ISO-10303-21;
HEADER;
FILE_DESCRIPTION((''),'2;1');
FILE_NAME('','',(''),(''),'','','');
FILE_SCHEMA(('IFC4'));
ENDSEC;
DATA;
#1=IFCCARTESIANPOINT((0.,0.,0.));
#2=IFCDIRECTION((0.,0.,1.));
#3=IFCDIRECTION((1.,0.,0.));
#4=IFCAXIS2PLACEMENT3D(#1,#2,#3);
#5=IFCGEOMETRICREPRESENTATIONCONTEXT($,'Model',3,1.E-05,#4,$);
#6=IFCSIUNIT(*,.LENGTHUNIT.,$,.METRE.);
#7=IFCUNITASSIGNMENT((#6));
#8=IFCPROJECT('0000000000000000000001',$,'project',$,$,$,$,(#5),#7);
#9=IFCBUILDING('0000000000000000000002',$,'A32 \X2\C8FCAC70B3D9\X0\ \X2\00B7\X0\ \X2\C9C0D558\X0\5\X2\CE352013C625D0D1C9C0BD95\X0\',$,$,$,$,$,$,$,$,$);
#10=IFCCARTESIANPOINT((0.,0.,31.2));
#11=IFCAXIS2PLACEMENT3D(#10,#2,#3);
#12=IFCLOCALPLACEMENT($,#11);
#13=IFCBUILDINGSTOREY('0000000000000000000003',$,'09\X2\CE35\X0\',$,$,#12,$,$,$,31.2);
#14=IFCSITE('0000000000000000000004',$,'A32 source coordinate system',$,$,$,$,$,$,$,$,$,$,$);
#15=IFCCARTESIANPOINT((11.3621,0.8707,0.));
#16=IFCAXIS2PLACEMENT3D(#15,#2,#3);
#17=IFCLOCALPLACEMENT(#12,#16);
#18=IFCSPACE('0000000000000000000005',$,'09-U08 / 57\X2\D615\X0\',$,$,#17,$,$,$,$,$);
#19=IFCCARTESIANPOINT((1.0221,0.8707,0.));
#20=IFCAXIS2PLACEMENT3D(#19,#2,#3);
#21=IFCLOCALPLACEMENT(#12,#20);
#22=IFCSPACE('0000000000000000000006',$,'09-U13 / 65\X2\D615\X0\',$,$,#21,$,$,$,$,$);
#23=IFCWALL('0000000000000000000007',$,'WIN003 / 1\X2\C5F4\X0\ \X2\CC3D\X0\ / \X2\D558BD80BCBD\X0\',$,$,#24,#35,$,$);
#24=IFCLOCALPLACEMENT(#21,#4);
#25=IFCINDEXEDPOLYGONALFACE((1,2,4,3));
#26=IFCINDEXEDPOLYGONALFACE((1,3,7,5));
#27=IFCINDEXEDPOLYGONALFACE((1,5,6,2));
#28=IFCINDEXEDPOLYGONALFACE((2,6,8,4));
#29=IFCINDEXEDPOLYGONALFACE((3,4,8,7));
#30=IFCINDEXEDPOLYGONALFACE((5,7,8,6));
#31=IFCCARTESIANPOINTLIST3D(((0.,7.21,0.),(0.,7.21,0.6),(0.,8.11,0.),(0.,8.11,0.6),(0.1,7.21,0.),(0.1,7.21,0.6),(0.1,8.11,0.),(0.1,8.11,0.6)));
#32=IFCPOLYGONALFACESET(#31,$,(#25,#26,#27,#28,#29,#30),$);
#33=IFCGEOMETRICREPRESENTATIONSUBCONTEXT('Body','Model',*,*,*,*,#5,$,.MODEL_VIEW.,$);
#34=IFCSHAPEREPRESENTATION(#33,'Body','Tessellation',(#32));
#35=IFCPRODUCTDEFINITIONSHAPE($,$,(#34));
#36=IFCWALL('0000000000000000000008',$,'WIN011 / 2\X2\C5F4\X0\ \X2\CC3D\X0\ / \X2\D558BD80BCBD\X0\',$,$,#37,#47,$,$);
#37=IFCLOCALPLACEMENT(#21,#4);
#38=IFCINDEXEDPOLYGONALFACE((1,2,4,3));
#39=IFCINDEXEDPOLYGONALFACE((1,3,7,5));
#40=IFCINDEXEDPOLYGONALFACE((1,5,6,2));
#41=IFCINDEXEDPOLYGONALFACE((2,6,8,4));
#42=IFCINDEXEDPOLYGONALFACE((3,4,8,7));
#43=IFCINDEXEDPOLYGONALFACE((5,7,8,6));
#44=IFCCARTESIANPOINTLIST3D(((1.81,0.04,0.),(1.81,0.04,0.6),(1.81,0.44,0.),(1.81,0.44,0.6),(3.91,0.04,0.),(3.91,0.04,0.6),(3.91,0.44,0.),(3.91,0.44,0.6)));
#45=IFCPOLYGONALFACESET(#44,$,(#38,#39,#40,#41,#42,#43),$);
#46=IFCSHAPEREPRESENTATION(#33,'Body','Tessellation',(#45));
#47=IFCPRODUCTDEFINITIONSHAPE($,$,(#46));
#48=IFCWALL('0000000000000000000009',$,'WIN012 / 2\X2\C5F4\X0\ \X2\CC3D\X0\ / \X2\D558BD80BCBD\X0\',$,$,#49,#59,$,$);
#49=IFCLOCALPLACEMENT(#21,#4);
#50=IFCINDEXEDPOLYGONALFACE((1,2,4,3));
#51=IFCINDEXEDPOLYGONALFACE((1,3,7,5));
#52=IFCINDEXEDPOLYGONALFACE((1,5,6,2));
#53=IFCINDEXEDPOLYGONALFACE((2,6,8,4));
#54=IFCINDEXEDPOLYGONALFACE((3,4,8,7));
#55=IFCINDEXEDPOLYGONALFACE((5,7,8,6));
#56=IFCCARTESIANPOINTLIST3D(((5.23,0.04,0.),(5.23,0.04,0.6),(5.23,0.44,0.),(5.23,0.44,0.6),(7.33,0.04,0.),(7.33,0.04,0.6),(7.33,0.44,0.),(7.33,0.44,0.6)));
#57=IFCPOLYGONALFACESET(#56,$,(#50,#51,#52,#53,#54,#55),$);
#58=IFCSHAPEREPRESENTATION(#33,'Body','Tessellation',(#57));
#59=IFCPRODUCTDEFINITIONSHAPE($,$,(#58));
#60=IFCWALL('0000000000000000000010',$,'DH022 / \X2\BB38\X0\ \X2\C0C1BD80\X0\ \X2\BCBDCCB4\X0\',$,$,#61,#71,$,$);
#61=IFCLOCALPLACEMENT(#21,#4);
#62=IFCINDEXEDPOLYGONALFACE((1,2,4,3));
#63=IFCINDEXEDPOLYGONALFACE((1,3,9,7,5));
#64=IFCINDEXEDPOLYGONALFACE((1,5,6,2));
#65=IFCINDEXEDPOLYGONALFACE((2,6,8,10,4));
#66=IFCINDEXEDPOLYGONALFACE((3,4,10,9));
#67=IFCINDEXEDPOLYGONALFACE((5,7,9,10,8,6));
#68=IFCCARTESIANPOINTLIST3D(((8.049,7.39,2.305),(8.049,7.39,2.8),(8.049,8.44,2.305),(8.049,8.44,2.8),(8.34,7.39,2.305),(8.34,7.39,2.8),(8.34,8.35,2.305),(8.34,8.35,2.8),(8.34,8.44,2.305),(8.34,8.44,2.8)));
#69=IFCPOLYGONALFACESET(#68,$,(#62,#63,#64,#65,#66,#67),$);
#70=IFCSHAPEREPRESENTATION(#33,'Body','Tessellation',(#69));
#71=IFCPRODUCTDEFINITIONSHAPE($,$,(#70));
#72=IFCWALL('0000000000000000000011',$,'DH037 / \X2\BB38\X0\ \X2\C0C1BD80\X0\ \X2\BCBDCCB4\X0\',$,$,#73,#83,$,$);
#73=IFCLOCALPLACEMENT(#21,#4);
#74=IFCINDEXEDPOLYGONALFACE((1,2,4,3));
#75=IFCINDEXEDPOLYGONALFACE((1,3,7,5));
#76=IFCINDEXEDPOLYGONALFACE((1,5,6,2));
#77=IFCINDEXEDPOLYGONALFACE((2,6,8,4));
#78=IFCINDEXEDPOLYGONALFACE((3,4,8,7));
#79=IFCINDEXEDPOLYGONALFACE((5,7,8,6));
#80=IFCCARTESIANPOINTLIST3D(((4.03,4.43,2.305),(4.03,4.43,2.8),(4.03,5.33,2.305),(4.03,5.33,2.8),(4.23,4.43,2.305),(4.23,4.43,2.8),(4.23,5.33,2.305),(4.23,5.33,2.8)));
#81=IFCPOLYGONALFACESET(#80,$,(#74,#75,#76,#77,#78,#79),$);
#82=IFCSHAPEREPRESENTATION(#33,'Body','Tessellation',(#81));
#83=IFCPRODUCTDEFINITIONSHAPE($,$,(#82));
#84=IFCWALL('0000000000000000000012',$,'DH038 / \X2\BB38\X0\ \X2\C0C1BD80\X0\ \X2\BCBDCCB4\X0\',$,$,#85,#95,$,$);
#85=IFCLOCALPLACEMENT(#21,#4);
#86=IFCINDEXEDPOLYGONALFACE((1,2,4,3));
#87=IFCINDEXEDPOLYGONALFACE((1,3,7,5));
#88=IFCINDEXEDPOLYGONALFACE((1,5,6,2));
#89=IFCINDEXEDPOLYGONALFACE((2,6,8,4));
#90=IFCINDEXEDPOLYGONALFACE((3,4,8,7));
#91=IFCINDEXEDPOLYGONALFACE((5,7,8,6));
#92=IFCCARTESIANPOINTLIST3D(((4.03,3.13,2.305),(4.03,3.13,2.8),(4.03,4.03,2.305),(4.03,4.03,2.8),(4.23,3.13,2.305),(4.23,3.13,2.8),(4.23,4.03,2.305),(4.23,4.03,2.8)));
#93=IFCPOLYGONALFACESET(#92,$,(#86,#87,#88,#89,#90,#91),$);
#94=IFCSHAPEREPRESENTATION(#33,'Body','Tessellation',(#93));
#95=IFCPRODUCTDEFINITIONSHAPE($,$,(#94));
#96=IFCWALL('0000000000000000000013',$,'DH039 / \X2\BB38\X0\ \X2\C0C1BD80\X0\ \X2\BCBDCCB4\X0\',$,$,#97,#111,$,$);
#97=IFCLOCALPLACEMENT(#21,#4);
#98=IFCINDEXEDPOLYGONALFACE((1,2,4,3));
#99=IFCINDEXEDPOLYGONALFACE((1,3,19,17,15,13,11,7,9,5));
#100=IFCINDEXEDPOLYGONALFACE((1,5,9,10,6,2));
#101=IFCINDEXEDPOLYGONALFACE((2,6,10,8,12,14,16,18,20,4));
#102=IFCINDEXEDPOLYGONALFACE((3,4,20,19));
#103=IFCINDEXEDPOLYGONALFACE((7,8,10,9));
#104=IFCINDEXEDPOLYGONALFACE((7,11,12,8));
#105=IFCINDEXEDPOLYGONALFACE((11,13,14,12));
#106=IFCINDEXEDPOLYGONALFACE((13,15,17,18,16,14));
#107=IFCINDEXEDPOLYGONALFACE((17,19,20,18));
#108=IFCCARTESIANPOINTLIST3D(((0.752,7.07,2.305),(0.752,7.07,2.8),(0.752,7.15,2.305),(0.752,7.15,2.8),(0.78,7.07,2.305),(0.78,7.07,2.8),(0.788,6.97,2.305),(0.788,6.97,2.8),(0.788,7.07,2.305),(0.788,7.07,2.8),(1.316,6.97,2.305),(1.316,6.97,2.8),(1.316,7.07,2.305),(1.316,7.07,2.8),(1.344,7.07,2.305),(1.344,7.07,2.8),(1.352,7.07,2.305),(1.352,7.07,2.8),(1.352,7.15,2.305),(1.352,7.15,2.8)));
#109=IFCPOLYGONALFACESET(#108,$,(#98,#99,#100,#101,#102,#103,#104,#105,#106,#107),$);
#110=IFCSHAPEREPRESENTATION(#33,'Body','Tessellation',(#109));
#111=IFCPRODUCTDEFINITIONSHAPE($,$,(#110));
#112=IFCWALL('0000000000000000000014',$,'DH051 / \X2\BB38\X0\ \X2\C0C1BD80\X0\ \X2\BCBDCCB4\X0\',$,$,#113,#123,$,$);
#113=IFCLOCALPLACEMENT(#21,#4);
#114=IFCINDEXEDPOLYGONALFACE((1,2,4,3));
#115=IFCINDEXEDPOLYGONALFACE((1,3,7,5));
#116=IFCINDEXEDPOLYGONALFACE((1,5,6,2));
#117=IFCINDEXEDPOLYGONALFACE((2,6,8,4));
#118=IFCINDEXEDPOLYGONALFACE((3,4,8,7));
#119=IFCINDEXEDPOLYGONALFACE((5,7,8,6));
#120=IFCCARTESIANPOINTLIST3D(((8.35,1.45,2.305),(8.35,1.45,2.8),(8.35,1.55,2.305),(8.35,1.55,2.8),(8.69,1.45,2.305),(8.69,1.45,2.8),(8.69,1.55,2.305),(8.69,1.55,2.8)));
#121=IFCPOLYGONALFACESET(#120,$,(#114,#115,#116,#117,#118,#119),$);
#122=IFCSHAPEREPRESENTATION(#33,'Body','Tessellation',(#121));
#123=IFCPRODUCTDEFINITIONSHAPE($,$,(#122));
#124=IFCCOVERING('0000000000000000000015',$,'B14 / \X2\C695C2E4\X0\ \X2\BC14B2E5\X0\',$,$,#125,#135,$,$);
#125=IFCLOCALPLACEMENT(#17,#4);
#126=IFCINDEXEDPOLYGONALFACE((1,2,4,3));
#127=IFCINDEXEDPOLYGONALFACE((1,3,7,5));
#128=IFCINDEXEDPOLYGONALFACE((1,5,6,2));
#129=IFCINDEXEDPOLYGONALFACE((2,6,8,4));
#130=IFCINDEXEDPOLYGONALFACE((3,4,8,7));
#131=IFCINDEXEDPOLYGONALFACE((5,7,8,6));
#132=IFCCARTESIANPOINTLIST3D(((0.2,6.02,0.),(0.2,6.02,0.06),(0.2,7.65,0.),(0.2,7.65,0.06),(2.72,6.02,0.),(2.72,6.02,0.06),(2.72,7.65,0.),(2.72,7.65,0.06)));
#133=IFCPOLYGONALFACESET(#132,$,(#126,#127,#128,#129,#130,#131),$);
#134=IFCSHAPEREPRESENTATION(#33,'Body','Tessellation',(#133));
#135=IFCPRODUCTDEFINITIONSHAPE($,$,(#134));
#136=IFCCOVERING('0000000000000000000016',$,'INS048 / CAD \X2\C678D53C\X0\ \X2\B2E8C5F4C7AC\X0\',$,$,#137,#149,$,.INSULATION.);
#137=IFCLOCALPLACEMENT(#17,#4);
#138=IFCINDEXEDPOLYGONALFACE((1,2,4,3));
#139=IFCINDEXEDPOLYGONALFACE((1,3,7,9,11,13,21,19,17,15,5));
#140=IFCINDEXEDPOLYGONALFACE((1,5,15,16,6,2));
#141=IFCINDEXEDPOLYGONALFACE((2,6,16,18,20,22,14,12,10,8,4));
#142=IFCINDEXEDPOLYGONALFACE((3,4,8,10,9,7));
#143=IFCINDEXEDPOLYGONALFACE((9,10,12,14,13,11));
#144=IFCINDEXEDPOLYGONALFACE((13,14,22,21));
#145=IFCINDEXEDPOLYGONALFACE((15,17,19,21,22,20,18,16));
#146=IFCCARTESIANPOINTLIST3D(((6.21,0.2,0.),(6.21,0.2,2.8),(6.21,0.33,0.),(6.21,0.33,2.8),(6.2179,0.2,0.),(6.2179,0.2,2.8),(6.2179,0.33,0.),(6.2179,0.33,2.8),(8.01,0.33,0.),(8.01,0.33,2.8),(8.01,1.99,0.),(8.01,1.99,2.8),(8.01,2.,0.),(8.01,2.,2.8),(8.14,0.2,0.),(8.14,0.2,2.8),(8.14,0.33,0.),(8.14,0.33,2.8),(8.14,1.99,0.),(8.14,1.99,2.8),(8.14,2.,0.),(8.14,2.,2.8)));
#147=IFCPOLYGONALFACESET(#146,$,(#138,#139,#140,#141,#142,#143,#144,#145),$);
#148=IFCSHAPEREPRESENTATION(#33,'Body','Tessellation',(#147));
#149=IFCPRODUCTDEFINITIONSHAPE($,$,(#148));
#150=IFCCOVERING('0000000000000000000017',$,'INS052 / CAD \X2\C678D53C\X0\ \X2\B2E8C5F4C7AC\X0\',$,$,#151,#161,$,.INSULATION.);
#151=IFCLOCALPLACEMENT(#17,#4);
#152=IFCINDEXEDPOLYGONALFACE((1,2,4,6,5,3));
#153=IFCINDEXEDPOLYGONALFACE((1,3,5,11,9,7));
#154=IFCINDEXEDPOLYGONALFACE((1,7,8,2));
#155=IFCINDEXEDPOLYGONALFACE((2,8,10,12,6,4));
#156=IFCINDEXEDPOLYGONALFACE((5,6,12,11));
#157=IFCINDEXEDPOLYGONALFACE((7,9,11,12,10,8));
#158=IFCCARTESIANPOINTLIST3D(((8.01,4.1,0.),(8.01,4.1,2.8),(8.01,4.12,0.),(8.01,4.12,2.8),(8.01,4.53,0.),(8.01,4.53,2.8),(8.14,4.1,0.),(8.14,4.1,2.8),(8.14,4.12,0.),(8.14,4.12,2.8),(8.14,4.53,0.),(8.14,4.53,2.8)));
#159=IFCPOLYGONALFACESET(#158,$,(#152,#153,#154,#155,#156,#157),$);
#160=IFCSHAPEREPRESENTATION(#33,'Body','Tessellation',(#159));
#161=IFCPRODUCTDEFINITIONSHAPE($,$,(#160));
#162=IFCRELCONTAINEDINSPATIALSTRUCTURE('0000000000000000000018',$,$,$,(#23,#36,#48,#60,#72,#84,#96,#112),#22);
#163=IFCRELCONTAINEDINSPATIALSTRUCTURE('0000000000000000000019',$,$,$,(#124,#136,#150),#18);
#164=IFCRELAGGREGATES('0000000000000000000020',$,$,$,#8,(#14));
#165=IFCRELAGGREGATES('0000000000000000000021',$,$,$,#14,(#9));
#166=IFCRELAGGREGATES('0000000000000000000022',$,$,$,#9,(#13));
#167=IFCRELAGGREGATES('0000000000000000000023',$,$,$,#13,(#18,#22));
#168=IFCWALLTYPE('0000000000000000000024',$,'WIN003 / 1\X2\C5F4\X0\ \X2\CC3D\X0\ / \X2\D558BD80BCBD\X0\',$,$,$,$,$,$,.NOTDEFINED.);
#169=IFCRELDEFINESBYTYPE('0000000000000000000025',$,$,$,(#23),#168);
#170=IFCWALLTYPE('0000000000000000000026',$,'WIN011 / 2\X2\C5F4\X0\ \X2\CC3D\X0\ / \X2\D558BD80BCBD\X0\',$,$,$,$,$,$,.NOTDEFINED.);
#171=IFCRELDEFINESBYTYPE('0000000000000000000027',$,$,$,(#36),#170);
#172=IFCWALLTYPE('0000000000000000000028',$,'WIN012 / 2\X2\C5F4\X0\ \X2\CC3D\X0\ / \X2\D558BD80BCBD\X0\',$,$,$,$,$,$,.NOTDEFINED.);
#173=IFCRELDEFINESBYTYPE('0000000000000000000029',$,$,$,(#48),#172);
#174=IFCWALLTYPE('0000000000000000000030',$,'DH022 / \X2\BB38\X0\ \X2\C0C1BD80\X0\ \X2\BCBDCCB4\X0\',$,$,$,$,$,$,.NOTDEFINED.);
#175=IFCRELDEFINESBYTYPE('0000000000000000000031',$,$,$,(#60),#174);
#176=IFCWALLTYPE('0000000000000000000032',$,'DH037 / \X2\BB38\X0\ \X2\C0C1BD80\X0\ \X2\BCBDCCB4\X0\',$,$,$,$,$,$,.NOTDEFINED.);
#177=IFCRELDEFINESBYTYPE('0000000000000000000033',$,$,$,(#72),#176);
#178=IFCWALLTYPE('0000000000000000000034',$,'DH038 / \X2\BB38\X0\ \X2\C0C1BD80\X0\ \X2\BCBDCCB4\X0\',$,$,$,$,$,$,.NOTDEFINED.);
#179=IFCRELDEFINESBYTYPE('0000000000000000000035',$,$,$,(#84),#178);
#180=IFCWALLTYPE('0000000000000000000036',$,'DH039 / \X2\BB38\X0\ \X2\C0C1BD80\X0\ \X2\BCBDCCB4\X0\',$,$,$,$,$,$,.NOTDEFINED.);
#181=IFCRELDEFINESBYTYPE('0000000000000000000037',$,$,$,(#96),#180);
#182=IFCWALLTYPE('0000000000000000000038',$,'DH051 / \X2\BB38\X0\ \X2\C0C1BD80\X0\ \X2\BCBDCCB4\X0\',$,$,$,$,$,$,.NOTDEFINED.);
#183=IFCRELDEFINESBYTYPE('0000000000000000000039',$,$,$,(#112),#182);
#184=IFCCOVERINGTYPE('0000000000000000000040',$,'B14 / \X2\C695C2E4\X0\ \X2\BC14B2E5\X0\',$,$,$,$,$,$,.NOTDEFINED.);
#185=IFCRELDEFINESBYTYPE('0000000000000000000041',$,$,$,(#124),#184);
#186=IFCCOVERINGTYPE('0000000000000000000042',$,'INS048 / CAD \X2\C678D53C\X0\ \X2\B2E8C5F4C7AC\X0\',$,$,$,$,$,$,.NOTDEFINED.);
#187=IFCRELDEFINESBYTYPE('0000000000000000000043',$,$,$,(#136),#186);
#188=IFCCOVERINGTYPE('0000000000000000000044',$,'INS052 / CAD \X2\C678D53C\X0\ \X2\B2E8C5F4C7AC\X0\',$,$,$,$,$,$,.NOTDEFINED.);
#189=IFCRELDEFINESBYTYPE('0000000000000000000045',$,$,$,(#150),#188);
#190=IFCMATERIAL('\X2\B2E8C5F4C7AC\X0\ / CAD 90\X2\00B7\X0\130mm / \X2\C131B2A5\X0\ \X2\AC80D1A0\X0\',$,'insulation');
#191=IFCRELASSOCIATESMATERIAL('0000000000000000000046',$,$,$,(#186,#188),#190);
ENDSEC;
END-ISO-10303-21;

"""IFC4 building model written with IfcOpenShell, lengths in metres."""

from ifc_helpers import new_model, si_unit, frame, origin, origin_with_axes, place, context, subcontext, project, spatial, polyline, outline, extrude, source, transform, mapped, material, type_object, type_shapes, element, save


model = new_model("IFC4")

# Units and contexts
model_context = context("Model", 3, precision=1e-05, world=origin_with_axes())
body_context = subcontext(model_context, "Body", "Model", "MODEL_VIEW")
ifc_project = project(units=[si_unit("LENGTHUNIT", "METRE")], contexts=[model_context])

# Site, building, storey, space
site = spatial("IfcSite", under=ifc_project, Name="A32 source coordinate system")
building = spatial("IfcBuilding", under=site, Name="A32 주거동 · 지하5층–옥탑지붕")
storey_placement = place(None, frame((0.0, 0.0, 31.2), z_axis=(0.0, 0.0, 1.0), x_axis=(1.0, 0.0, 0.0)))
storey = spatial("IfcBuildingStorey", under=building, at=storey_placement, Name="09층", Elevation=31.2)
space_1_placement = place(storey_placement, frame((11.3621, 0.8707, 0.0), z_axis=(0.0, 0.0, 1.0), x_axis=(1.0, 0.0, 0.0)))
space_1 = spatial("IfcSpace", under=storey, at=space_1_placement, Name="09-U08 / 57형")

# Shared definitions
space_2_placement = place(storey_placement, frame((1.0221, 0.8707, 0.0), z_axis=(0.0, 0.0, 1.0), x_axis=(1.0, 0.0, 0.0)))
space_2 = spatial("IfcSpace", under=storey, at=space_2_placement, Name="09-U13 / 65형")

# Walls
wall_type_1 = type_object("IfcWallType", Name="WIN003 / 1열 창 / 하부벽", PredefinedType="NOTDEFINED")
shared_shape_1 = source(origin(), body_context, "Body", "SweptSolid", [
    extrude(outline(polyline([(0.0, 8.11), (0.1, 8.11), (0.1, 7.21), (0.0, 7.21), (0.0, 8.11)])), origin(), (0.0, 0.0, 1.0), 0.6),
])
type_shapes(wall_type_1, [shared_shape_1])
wall_1_placement = place(space_2_placement, origin_with_axes())
element("IfcWall", 1, at=wall_1_placement, inside=space_2, type_object=wall_type_1, Name="WIN003 / 1열 창 / 하부벽", context=body_context, shape_type="MappedRepresentation", body=[
    mapped(shared_shape_1, transform((0.0, 0.0, 0.0), scale=1.0)),
])
wall_type_2 = type_object("IfcWallType", Name="WIN011 / 2열 창 / 하부벽", PredefinedType="NOTDEFINED")
shared_shape_2 = source(origin(), body_context, "Body", "SweptSolid", [
    extrude(outline(polyline([(1.81, 0.44), (3.91, 0.44), (3.91, 0.04), (1.81, 0.04), (1.81, 0.44)])), origin(), (0.0, 0.0, 1.0), 0.6),
])
type_shapes(wall_type_2, [shared_shape_2])
wall_2_placement = place(space_2_placement, origin_with_axes())
element("IfcWall", 2, at=wall_2_placement, inside=space_2, type_object=wall_type_2, Name="WIN011 / 2열 창 / 하부벽", context=body_context, shape_type="MappedRepresentation", body=[
    mapped(shared_shape_2, transform((0.0, 0.0, 0.0), scale=1.0)),
])
wall_type_3 = type_object("IfcWallType", Name="WIN012 / 2열 창 / 하부벽", PredefinedType="NOTDEFINED")
shared_shape_3 = source(origin(), body_context, "Body", "SweptSolid", [
    extrude(outline(polyline([(5.23, 0.44), (7.33, 0.44), (7.33, 0.04), (5.23, 0.04), (5.23, 0.44)])), origin(), (0.0, 0.0, 1.0), 0.6),
])
type_shapes(wall_type_3, [shared_shape_3])
wall_3_placement = place(space_2_placement, origin_with_axes())
element("IfcWall", 3, at=wall_3_placement, inside=space_2, type_object=wall_type_3, Name="WIN012 / 2열 창 / 하부벽", context=body_context, shape_type="MappedRepresentation", body=[
    mapped(shared_shape_3, transform((0.0, 0.0, 0.0), scale=1.0)),
])
wall_type_4 = type_object("IfcWallType", Name="DH022 / 문 상부 벽체", PredefinedType="NOTDEFINED")
shared_shape_4 = source(origin(), body_context, "Body", "SweptSolid", [
    extrude(outline(polyline([(8.049, 7.39), (8.049, 8.44), (8.34, 8.44), (8.34, 8.35), (8.34, 8.35), (8.34, 7.39), (8.049, 7.39)])), frame((0.0, 0.0, 2.305)), (0.0, 0.0, 1.0), 0.495),
])
type_shapes(wall_type_4, [shared_shape_4])
wall_4_placement = place(space_2_placement, origin_with_axes())
element("IfcWall", 4, at=wall_4_placement, inside=space_2, type_object=wall_type_4, Name="DH022 / 문 상부 벽체", context=body_context, shape_type="MappedRepresentation", body=[
    mapped(shared_shape_4, transform((0.0, 0.0, 0.0), scale=1.0)),
])
wall_type_5 = type_object("IfcWallType", Name="DH037 / 문 상부 벽체", PredefinedType="NOTDEFINED")
shared_shape_5 = source(origin(), body_context, "Body", "SweptSolid", [
    extrude(outline(polyline([(4.23, 5.33), (4.23, 4.43), (4.03, 4.43), (4.03, 5.33), (4.23, 5.33)])), frame((0.0, 0.0, 2.305)), (0.0, 0.0, 1.0), 0.495),
])
type_shapes(wall_type_5, [shared_shape_5])
wall_5_placement = place(space_2_placement, origin_with_axes())
element("IfcWall", 5, at=wall_5_placement, inside=space_2, type_object=wall_type_5, Name="DH037 / 문 상부 벽체", context=body_context, shape_type="MappedRepresentation", body=[
    mapped(shared_shape_5, transform((0.0, 0.0, 0.0), scale=1.0)),
])
wall_type_6 = type_object("IfcWallType", Name="DH038 / 문 상부 벽체", PredefinedType="NOTDEFINED")
shared_shape_6 = source(origin(), body_context, "Body", "SweptSolid", [
    extrude(outline(polyline([(4.23, 4.03), (4.23, 3.13), (4.03, 3.13), (4.03, 4.03), (4.23, 4.03)])), frame((0.0, 0.0, 2.305)), (0.0, 0.0, 1.0), 0.495),
])
type_shapes(wall_type_6, [shared_shape_6])
wall_6_placement = place(space_2_placement, origin_with_axes())
element("IfcWall", 6, at=wall_6_placement, inside=space_2, type_object=wall_type_6, Name="DH038 / 문 상부 벽체", context=body_context, shape_type="MappedRepresentation", body=[
    mapped(shared_shape_6, transform((0.0, 0.0, 0.0), scale=1.0)),
])
wall_type_7 = type_object("IfcWallType", Name="DH039 / 문 상부 벽체", PredefinedType="NOTDEFINED")
shared_shape_7 = source(origin(), body_context, "Body", "SweptSolid", [
    extrude(outline(polyline([(1.316, 7.07), (1.316, 6.97), (0.788, 6.97), (0.788, 7.07), (0.78, 7.07), (0.752, 7.07), (0.752, 7.15), (1.352, 7.15), (1.352, 7.07), (1.344, 7.07), (1.316, 7.07)])), frame((0.0, 0.0, 2.305)), (0.0, 0.0, 1.0), 0.495),
])
type_shapes(wall_type_7, [shared_shape_7])
wall_7_placement = place(space_2_placement, origin_with_axes())
element("IfcWall", 7, at=wall_7_placement, inside=space_2, type_object=wall_type_7, Name="DH039 / 문 상부 벽체", context=body_context, shape_type="MappedRepresentation", body=[
    mapped(shared_shape_7, transform((0.0, 0.0, 0.0), scale=1.0)),
])
wall_type_8 = type_object("IfcWallType", Name="DH051 / 문 상부 벽체", PredefinedType="NOTDEFINED")
shared_shape_8 = source(origin(), body_context, "Body", "SweptSolid", [
    extrude(outline(polyline([(8.69, 1.55), (8.69, 1.45), (8.35, 1.45), (8.35, 1.55), (8.69, 1.55)])), frame((0.0, 0.0, 2.305)), (0.0, 0.0, 1.0), 0.495),
])
type_shapes(wall_type_8, [shared_shape_8])
wall_8_placement = place(space_2_placement, origin_with_axes())
element("IfcWall", 8, at=wall_8_placement, inside=space_2, type_object=wall_type_8, Name="DH051 / 문 상부 벽체", context=body_context, shape_type="MappedRepresentation", body=[
    mapped(shared_shape_8, transform((0.0, 0.0, 0.0), scale=1.0)),
])

# Coverings
covering_type_1 = type_object("IfcCoveringType", Name="B14 / 욕실 바닥", PredefinedType="NOTDEFINED")
shared_shape_9 = source(origin(), body_context, "Body", "SweptSolid", [
    extrude(outline(polyline([(0.2, 7.65), (2.72, 7.65), (2.72, 6.02), (0.2, 6.02), (0.2, 7.65)])), origin(), (0.0, 0.0, 1.0), 0.06),
])
type_shapes(covering_type_1, [shared_shape_9])
covering_1_placement = place(space_1_placement, origin_with_axes())
element("IfcCovering", 9, at=covering_1_placement, inside=space_1, type_object=covering_type_1, Name="B14 / 욕실 바닥", context=body_context, shape_type="MappedRepresentation", body=[
    mapped(shared_shape_9, transform((0.0, 0.0, 0.0), scale=1.0)),
])
ifc_material = material(Name="단열재 / CAD 90·130mm / 성능 검토", Category="insulation")
covering_type_2 = type_object("IfcCoveringType", Name="INS048 / CAD 외피 단열재", PredefinedType="NOTDEFINED", material=ifc_material)
shared_shape_10 = source(origin(), body_context, "Body", "SweptSolid", [
    extrude(outline(polyline([(8.01, 1.99), (8.01, 2.0), (8.14, 2.0), (8.14, 1.99), (8.14, 0.33), (8.14, 0.2), (6.2179, 0.2), (6.21, 0.2), (6.21, 0.33), (6.2179, 0.33), (8.01, 0.33), (8.01, 1.99)])), origin(), (0.0, 0.0, 1.0), 2.8),
])
type_shapes(covering_type_2, [shared_shape_10])
covering_2_placement = place(space_1_placement, origin_with_axes())
element("IfcCovering", 10, at=covering_2_placement, inside=space_1, type_object=covering_type_2, Name="INS048 / CAD 외피 단열재", PredefinedType="INSULATION", context=body_context, shape_type="MappedRepresentation", body=[
    mapped(shared_shape_10, transform((0.0, 0.0, 0.0), scale=1.0)),
])
covering_type_3 = type_object("IfcCoveringType", Name="INS052 / CAD 외피 단열재", PredefinedType="NOTDEFINED", material=ifc_material)
shared_shape_11 = source(origin(), body_context, "Body", "SweptSolid", [
    extrude(outline(polyline([(8.14, 4.1), (8.01, 4.1), (8.01, 4.12), (8.01, 4.53), (8.14, 4.53), (8.14, 4.12), (8.14, 4.1)])), origin(), (0.0, 0.0, 1.0), 2.8),
])
type_shapes(covering_type_3, [shared_shape_11])
covering_3_placement = place(space_1_placement, origin_with_axes())
element("IfcCovering", 11, at=covering_3_placement, inside=space_1, type_object=covering_type_3, Name="INS052 / CAD 외피 단열재", PredefinedType="INSULATION", context=body_context, shape_type="MappedRepresentation", body=[
    mapped(shared_shape_11, transform((0.0, 0.0, 0.0), scale=1.0)),
])

save(model, "model.ifc")
